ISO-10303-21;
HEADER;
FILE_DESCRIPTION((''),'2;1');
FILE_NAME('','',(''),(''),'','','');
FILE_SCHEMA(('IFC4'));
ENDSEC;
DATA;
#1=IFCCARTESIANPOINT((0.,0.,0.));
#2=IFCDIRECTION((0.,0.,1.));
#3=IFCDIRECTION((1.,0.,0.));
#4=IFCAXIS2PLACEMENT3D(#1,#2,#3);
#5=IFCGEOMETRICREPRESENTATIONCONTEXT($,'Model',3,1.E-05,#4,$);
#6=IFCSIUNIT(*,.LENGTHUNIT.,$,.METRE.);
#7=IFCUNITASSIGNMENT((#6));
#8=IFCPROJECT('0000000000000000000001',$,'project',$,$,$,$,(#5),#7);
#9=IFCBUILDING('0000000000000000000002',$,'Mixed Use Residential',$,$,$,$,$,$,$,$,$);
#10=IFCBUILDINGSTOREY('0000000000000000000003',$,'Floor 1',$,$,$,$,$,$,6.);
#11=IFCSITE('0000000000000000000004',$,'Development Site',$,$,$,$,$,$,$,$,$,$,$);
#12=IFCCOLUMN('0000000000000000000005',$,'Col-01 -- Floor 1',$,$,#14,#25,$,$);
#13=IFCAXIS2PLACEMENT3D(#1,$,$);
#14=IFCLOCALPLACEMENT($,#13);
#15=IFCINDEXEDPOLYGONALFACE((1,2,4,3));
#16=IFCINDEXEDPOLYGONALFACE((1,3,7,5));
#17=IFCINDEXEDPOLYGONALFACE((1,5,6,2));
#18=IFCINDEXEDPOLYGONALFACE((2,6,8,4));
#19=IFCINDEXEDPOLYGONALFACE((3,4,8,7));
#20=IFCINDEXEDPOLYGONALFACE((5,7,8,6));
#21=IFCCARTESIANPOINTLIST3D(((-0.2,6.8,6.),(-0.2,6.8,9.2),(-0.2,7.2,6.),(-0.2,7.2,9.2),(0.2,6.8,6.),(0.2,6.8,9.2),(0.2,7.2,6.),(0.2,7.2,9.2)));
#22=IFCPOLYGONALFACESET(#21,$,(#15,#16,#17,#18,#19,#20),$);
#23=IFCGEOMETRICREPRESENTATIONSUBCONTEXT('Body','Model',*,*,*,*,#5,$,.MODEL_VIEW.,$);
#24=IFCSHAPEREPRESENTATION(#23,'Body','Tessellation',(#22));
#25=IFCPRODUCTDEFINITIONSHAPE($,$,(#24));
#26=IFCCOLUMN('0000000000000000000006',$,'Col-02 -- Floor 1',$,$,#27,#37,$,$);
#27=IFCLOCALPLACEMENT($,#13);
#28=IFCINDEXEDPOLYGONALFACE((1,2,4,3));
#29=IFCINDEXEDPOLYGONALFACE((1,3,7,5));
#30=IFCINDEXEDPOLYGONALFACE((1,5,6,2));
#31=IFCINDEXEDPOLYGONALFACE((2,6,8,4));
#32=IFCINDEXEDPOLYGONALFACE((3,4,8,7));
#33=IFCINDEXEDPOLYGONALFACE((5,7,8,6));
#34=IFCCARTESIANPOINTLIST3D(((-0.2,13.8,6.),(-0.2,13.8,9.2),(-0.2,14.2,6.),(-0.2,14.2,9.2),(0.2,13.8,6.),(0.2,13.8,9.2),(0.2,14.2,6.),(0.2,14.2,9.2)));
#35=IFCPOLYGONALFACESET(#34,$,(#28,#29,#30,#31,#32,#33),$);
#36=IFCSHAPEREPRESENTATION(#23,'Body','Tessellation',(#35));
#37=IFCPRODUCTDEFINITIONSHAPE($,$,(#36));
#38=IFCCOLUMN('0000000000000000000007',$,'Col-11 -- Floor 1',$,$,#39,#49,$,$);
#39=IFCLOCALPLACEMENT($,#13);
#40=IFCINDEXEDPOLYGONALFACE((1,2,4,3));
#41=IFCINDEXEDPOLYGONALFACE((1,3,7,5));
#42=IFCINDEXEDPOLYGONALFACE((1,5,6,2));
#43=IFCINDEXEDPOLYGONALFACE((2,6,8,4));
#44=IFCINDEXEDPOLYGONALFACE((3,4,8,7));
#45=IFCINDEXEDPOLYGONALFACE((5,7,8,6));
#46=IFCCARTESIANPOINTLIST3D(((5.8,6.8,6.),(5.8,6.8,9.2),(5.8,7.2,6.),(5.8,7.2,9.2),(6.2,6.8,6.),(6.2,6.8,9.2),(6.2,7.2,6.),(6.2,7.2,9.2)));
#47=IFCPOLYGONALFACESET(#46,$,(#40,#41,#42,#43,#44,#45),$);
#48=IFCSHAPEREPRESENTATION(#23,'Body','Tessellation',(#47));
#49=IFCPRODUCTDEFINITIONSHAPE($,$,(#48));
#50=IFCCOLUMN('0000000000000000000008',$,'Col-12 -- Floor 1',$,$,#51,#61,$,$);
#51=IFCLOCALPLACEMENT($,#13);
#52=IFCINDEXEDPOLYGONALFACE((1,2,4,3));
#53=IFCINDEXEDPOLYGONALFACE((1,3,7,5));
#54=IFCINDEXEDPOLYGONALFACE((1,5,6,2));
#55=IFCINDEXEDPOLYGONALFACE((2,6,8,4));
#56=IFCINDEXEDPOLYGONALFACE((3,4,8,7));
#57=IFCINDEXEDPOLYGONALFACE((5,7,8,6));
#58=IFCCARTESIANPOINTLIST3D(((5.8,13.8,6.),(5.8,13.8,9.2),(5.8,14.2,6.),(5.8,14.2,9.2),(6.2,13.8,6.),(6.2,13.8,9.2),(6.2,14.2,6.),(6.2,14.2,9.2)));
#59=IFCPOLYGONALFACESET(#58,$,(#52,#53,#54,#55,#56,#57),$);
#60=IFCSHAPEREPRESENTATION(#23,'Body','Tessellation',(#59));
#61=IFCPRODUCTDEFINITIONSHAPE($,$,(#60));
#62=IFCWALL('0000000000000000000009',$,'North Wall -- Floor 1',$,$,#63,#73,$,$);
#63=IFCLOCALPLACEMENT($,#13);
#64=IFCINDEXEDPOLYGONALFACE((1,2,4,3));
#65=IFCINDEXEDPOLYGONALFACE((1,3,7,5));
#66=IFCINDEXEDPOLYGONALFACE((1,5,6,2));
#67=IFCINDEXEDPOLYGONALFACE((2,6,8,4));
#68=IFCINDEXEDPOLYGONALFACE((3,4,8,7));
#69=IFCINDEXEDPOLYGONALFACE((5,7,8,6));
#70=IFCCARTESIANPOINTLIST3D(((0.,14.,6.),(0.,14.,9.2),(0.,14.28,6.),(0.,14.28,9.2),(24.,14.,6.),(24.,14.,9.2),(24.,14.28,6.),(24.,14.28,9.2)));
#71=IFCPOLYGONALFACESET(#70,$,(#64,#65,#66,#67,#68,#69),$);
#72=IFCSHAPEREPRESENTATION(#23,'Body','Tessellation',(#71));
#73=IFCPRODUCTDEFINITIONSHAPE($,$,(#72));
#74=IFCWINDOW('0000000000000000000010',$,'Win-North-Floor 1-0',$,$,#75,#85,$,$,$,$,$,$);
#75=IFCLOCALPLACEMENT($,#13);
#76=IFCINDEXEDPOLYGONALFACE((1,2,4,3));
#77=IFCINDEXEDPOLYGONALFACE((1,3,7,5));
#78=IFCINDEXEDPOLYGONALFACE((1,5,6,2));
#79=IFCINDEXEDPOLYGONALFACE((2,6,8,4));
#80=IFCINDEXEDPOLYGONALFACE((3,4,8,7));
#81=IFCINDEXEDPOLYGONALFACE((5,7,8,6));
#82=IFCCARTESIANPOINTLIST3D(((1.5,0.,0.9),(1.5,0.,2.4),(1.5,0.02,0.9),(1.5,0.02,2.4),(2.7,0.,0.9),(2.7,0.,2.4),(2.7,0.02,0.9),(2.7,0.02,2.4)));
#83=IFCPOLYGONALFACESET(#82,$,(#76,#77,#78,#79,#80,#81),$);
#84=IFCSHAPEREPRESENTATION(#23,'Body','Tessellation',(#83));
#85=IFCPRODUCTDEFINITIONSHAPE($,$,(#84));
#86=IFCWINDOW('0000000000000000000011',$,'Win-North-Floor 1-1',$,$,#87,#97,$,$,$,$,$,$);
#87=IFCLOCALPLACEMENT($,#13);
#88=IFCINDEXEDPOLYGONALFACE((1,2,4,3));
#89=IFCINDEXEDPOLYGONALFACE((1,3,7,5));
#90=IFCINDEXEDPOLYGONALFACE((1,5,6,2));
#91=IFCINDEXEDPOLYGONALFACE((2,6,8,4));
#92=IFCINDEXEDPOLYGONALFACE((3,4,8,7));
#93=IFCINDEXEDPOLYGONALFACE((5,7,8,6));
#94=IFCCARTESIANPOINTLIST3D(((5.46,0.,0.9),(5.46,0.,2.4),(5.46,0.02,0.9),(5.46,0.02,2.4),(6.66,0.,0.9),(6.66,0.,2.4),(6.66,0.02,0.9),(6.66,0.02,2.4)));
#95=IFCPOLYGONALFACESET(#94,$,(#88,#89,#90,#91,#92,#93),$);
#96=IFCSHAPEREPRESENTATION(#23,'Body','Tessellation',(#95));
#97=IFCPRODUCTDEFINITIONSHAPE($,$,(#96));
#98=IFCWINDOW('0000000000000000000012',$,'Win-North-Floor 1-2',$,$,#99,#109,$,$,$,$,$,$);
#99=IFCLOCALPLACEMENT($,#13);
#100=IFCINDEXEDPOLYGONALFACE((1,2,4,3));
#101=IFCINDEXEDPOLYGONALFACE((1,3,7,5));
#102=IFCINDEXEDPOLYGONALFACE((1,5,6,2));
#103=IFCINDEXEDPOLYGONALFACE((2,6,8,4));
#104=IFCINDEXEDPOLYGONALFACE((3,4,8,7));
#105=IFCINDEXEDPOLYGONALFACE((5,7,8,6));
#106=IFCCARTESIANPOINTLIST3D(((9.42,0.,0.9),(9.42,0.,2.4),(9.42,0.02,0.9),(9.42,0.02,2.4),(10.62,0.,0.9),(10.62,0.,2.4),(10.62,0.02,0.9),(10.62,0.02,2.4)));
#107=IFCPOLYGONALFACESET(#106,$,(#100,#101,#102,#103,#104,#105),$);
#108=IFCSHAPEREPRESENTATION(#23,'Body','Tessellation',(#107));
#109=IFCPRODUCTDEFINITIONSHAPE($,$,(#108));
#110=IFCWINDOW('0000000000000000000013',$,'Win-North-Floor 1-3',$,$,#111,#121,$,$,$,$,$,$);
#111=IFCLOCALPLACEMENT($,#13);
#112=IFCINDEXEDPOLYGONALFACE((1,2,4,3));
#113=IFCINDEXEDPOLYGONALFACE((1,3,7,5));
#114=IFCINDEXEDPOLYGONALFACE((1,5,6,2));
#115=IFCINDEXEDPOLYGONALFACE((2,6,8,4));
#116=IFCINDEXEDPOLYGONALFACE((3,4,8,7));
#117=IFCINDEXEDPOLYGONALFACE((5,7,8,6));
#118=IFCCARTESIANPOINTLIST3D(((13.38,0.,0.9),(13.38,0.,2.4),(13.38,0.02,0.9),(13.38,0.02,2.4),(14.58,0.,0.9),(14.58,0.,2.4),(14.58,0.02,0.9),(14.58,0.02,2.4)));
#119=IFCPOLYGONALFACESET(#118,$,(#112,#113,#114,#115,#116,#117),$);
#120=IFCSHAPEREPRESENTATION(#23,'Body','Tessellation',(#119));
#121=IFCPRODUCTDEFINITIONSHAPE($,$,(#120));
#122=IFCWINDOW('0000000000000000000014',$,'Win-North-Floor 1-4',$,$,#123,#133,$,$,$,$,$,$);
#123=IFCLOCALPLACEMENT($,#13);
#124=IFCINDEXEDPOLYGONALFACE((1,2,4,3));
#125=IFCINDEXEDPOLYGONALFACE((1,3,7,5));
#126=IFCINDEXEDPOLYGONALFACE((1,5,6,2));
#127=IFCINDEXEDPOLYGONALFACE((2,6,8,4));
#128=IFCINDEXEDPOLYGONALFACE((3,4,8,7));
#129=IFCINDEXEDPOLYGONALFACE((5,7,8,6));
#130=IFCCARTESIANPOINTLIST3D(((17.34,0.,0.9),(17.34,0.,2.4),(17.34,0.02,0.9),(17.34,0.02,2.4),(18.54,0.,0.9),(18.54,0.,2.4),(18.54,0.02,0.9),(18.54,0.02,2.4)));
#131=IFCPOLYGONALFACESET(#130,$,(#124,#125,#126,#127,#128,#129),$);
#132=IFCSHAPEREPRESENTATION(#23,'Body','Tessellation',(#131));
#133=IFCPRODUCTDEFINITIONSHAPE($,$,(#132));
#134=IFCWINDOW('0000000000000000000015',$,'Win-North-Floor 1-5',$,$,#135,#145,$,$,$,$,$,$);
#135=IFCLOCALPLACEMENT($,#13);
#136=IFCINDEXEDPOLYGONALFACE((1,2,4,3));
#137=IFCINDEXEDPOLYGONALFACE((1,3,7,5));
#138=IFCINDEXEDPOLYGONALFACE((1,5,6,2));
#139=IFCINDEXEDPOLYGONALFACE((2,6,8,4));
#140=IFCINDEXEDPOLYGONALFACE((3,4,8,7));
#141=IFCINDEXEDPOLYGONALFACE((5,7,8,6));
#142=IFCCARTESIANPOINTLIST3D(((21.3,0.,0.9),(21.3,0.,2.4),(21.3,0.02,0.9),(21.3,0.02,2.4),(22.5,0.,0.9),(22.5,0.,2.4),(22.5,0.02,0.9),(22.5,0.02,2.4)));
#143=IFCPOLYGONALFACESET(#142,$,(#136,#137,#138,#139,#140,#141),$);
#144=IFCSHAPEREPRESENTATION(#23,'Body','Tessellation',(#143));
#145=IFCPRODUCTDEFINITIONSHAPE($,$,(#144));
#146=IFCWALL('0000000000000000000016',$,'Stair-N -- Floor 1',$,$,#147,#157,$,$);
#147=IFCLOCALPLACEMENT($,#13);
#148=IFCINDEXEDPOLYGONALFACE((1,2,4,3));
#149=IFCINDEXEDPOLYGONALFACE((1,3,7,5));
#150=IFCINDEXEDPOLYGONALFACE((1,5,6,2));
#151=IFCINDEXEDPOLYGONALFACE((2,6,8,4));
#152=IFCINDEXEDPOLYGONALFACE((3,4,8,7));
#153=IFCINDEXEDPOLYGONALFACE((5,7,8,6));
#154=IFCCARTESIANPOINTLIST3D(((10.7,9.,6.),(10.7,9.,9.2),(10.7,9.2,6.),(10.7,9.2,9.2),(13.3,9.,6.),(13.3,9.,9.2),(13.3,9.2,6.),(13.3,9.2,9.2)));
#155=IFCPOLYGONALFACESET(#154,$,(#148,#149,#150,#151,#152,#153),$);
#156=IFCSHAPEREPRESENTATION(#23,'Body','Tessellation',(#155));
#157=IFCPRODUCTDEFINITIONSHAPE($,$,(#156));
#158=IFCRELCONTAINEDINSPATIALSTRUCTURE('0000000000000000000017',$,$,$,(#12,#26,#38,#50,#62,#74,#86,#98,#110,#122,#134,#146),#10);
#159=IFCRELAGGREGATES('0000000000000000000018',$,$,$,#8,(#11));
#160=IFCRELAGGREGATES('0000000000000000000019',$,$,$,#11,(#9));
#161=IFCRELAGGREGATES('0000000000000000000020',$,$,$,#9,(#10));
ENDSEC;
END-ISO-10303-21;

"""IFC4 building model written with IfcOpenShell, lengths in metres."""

from ifc_helpers import new_model, si_unit, frame, origin_with_axes, place, context, subcontext, project, spatial, indexed_curve, rectangle, outline, extrude, element, fill, save


model = new_model("IFC4")

# Units and contexts
model_context = context("Model", 3, precision=1e-05, world=origin_with_axes())
body_context = subcontext(model_context, "Body", "Model", "MODEL_VIEW")
ifc_project = project(units=[si_unit("LENGTHUNIT", "METRE")], contexts=[model_context])

# Site, building, storey
site = spatial("IfcSite", under=ifc_project, Name="Development Site")
building = spatial("IfcBuilding", under=site, Name="Mixed Use Residential")
storey = spatial("IfcBuildingStorey", under=building, Name="Floor 1", Elevation=6.0)

# Columns
for number, where, z_axis, x_axis, name in (
    (1, (0.0, 7.0, 6.0), (0.0, 0.0, 1.0), (1.0, 0.0, 0.0), "Col-01 -- Floor 1"),
    (2, (0.0, 14.0, 6.0), (0.0, 0.0, 1.0), (1.0, 0.0, 0.0), "Col-02 -- Floor 1"),
    (3, (6.0, 7.0, 6.0), (0.0, 0.0, 1.0), (1.0, 0.0, 0.0), "Col-11 -- Floor 1"),
    (4, (6.0, 14.0, 6.0), (0.0, 0.0, 1.0), (1.0, 0.0, 0.0), "Col-12 -- Floor 1"),
):
    element("IfcColumn", number, at=place(None, frame(where, z_axis=z_axis, x_axis=x_axis)), inside=storey, Name=name, context=body_context, shape_type="SweptSolid", body=[
        extrude(rectangle(XDim=0.4, YDim=0.4), origin_with_axes(), (0.0, 0.0, 1.0), 3.2),
    ])

# Wall, openings, windows
wall_1_placement = place(None, frame((0.0, 14.0, 6.0), z_axis=(0.0, 0.0, 1.0), x_axis=(1.0, 0.0, 0.0)))
wall_1 = element("IfcWall", 5, at=wall_1_placement, inside=storey, Name="North Wall -- Floor 1", context=body_context, shape_type="SweptSolid", body=[
    extrude(outline(indexed_curve([(0.0, 0.0), (0.0, 0.28), (24.0, 0.28), (24.0, 0.0), (0.0, 0.0)], self_intersect=False)), origin_with_axes(), (0.0, 0.0, 1.0), 3.2),
])
opening_1_placement = place(wall_1_placement, frame((1.5, -14.0, -5.1), z_axis=(0.0, 0.0, 1.0), x_axis=(1.0, 0.0, 0.0)))
opening_1 = element("IfcOpeningElement", 6, at=opening_1_placement, cuts=wall_1, context=body_context, shape_type="SweptSolid", body=[
    extrude(outline(indexed_curve([(0.0, 0.0), (0.0, 0.28), (1.2, 0.28), (1.2, 0.0), (0.0, 0.0)], self_intersect=False)), origin_with_axes(), (0.0, 0.0, 1.0), 1.5),
])
opening_2_placement = place(wall_1_placement, frame((5.46, -14.0, -5.1), z_axis=(0.0, 0.0, 1.0), x_axis=(1.0, 0.0, 0.0)))
opening_2 = element("IfcOpeningElement", 7, at=opening_2_placement, cuts=wall_1, context=body_context, shape_type="SweptSolid", body=[
    extrude(outline(indexed_curve([(0.0, 0.0), (0.0, 0.28), (1.2, 0.28), (1.2, 0.0), (0.0, 0.0)], self_intersect=False)), origin_with_axes(), (0.0, 0.0, 1.0), 1.5),
])
opening_3_placement = place(wall_1_placement, frame((9.42, -14.0, -5.1), z_axis=(0.0, 0.0, 1.0), x_axis=(1.0, 0.0, 0.0)))
opening_3 = element("IfcOpeningElement", 8, at=opening_3_placement, cuts=wall_1, context=body_context, shape_type="SweptSolid", body=[
    extrude(outline(indexed_curve([(0.0, 0.0), (0.0, 0.28), (1.2, 0.28), (1.2, 0.0), (0.0, 0.0)], self_intersect=False)), origin_with_axes(), (0.0, 0.0, 1.0), 1.5),
])
opening_4_placement = place(wall_1_placement, frame((13.38, -14.0, -5.1), z_axis=(0.0, 0.0, 1.0), x_axis=(1.0, 0.0, 0.0)))
opening_4 = element("IfcOpeningElement", 9, at=opening_4_placement, cuts=wall_1, context=body_context, shape_type="SweptSolid", body=[
    extrude(outline(indexed_curve([(0.0, 0.0), (0.0, 0.28), (1.2, 0.28), (1.2, 0.0), (0.0, 0.0)], self_intersect=False)), origin_with_axes(), (0.0, 0.0, 1.0), 1.5),
])
opening_5_placement = place(wall_1_placement, frame((17.34, -14.0, -5.1), z_axis=(0.0, 0.0, 1.0), x_axis=(1.0, 0.0, 0.0)))
opening_5 = element("IfcOpeningElement", 10, at=opening_5_placement, cuts=wall_1, context=body_context, shape_type="SweptSolid", body=[
    extrude(outline(indexed_curve([(0.0, 0.0), (0.0, 0.28), (1.2, 0.28), (1.2, 0.0), (0.0, 0.0)], self_intersect=False)), origin_with_axes(), (0.0, 0.0, 1.0), 1.5),
])
opening_6_placement = place(wall_1_placement, frame((21.3, -14.0, -5.1), z_axis=(0.0, 0.0, 1.0), x_axis=(1.0, 0.0, 0.0)))
opening_6 = element("IfcOpeningElement", 11, at=opening_6_placement, cuts=wall_1, context=body_context, shape_type="SweptSolid", body=[
    extrude(outline(indexed_curve([(0.0, 0.0), (0.0, 0.28), (1.2, 0.28), (1.2, 0.0), (0.0, 0.0)], self_intersect=False)), origin_with_axes(), (0.0, 0.0, 1.0), 1.5),
])
window_1_placement = place(None, frame((1.5, 0.0, 0.9), z_axis=(0.0, 0.0, 1.0), x_axis=(1.0, 0.0, 0.0)))
window_1 = element("IfcWindow", 12, at=window_1_placement, inside=storey, Name="Win-North-Floor 1-0", context=body_context, shape_type="SweptSolid", body=[
    extrude(outline(indexed_curve([(0.0, 0.0), (0.0, 0.02), (1.2, 0.02), (1.2, 0.0), (0.0, 0.0)], self_intersect=False)), origin_with_axes(), (0.0, 0.0, 1.0), 1.5),
])
fill(opening_1, window_1)
window_2_placement = place(None, frame((5.46, 0.0, 0.9), z_axis=(0.0, 0.0, 1.0), x_axis=(1.0, 0.0, 0.0)))
window_2 = element("IfcWindow", 13, at=window_2_placement, inside=storey, Name="Win-North-Floor 1-1", context=body_context, shape_type="SweptSolid", body=[
    extrude(outline(indexed_curve([(0.0, 0.0), (0.0, 0.02), (1.2, 0.02), (1.2, 0.0), (0.0, 0.0)], self_intersect=False)), origin_with_axes(), (0.0, 0.0, 1.0), 1.5),
])
fill(opening_2, window_2)
window_3_placement = place(None, frame((9.42, 0.0, 0.9), z_axis=(0.0, 0.0, 1.0), x_axis=(1.0, 0.0, 0.0)))
window_3 = element("IfcWindow", 14, at=window_3_placement, inside=storey, Name="Win-North-Floor 1-2", context=body_context, shape_type="SweptSolid", body=[
    extrude(outline(indexed_curve([(0.0, 0.0), (0.0, 0.02), (1.2, 0.02), (1.2, 0.0), (0.0, 0.0)], self_intersect=False)), origin_with_axes(), (0.0, 0.0, 1.0), 1.5),
])
fill(opening_3, window_3)
window_4_placement = place(None, frame((13.38, 0.0, 0.9), z_axis=(0.0, 0.0, 1.0), x_axis=(1.0, 0.0, 0.0)))
window_4 = element("IfcWindow", 15, at=window_4_placement, inside=storey, Name="Win-North-Floor 1-3", context=body_context, shape_type="SweptSolid", body=[
    extrude(outline(indexed_curve([(0.0, 0.0), (0.0, 0.02), (1.2, 0.02), (1.2, 0.0), (0.0, 0.0)], self_intersect=False)), origin_with_axes(), (0.0, 0.0, 1.0), 1.5),
])
fill(opening_4, window_4)
window_5_placement = place(None, frame((17.34, 0.0, 0.9), z_axis=(0.0, 0.0, 1.0), x_axis=(1.0, 0.0, 0.0)))
window_5 = element("IfcWindow", 16, at=window_5_placement, inside=storey, Name="Win-North-Floor 1-4", context=body_context, shape_type="SweptSolid", body=[
    extrude(outline(indexed_curve([(0.0, 0.0), (0.0, 0.02), (1.2, 0.02), (1.2, 0.0), (0.0, 0.0)], self_intersect=False)), origin_with_axes(), (0.0, 0.0, 1.0), 1.5),
])
fill(opening_5, window_5)
window_6_placement = place(None, frame((21.3, 0.0, 0.9), z_axis=(0.0, 0.0, 1.0), x_axis=(1.0, 0.0, 0.0)))
window_6 = element("IfcWindow", 17, at=window_6_placement, inside=storey, Name="Win-North-Floor 1-5", context=body_context, shape_type="SweptSolid", body=[
    extrude(outline(indexed_curve([(0.0, 0.0), (0.0, 0.02), (1.2, 0.02), (1.2, 0.0), (0.0, 0.0)], self_intersect=False)), origin_with_axes(), (0.0, 0.0, 1.0), 1.5),
])
fill(opening_6, window_6)

# Wall
wall_2_placement = place(None, frame((10.7, 9.0, 6.0), z_axis=(0.0, 0.0, 1.0), x_axis=(1.0, 0.0, 0.0)))
element("IfcWall", 18, at=wall_2_placement, inside=storey, Name="Stair-N -- Floor 1", context=body_context, shape_type="SweptSolid", body=[
    extrude(outline(indexed_curve([(0.0, 0.0), (0.0, 0.2), (2.6, 0.2), (2.6, 0.0), (0.0, 0.0)], self_intersect=False)), origin_with_axes(), (0.0, 0.0, 1.0), 3.2),
])

save(model, "model.ifc")
